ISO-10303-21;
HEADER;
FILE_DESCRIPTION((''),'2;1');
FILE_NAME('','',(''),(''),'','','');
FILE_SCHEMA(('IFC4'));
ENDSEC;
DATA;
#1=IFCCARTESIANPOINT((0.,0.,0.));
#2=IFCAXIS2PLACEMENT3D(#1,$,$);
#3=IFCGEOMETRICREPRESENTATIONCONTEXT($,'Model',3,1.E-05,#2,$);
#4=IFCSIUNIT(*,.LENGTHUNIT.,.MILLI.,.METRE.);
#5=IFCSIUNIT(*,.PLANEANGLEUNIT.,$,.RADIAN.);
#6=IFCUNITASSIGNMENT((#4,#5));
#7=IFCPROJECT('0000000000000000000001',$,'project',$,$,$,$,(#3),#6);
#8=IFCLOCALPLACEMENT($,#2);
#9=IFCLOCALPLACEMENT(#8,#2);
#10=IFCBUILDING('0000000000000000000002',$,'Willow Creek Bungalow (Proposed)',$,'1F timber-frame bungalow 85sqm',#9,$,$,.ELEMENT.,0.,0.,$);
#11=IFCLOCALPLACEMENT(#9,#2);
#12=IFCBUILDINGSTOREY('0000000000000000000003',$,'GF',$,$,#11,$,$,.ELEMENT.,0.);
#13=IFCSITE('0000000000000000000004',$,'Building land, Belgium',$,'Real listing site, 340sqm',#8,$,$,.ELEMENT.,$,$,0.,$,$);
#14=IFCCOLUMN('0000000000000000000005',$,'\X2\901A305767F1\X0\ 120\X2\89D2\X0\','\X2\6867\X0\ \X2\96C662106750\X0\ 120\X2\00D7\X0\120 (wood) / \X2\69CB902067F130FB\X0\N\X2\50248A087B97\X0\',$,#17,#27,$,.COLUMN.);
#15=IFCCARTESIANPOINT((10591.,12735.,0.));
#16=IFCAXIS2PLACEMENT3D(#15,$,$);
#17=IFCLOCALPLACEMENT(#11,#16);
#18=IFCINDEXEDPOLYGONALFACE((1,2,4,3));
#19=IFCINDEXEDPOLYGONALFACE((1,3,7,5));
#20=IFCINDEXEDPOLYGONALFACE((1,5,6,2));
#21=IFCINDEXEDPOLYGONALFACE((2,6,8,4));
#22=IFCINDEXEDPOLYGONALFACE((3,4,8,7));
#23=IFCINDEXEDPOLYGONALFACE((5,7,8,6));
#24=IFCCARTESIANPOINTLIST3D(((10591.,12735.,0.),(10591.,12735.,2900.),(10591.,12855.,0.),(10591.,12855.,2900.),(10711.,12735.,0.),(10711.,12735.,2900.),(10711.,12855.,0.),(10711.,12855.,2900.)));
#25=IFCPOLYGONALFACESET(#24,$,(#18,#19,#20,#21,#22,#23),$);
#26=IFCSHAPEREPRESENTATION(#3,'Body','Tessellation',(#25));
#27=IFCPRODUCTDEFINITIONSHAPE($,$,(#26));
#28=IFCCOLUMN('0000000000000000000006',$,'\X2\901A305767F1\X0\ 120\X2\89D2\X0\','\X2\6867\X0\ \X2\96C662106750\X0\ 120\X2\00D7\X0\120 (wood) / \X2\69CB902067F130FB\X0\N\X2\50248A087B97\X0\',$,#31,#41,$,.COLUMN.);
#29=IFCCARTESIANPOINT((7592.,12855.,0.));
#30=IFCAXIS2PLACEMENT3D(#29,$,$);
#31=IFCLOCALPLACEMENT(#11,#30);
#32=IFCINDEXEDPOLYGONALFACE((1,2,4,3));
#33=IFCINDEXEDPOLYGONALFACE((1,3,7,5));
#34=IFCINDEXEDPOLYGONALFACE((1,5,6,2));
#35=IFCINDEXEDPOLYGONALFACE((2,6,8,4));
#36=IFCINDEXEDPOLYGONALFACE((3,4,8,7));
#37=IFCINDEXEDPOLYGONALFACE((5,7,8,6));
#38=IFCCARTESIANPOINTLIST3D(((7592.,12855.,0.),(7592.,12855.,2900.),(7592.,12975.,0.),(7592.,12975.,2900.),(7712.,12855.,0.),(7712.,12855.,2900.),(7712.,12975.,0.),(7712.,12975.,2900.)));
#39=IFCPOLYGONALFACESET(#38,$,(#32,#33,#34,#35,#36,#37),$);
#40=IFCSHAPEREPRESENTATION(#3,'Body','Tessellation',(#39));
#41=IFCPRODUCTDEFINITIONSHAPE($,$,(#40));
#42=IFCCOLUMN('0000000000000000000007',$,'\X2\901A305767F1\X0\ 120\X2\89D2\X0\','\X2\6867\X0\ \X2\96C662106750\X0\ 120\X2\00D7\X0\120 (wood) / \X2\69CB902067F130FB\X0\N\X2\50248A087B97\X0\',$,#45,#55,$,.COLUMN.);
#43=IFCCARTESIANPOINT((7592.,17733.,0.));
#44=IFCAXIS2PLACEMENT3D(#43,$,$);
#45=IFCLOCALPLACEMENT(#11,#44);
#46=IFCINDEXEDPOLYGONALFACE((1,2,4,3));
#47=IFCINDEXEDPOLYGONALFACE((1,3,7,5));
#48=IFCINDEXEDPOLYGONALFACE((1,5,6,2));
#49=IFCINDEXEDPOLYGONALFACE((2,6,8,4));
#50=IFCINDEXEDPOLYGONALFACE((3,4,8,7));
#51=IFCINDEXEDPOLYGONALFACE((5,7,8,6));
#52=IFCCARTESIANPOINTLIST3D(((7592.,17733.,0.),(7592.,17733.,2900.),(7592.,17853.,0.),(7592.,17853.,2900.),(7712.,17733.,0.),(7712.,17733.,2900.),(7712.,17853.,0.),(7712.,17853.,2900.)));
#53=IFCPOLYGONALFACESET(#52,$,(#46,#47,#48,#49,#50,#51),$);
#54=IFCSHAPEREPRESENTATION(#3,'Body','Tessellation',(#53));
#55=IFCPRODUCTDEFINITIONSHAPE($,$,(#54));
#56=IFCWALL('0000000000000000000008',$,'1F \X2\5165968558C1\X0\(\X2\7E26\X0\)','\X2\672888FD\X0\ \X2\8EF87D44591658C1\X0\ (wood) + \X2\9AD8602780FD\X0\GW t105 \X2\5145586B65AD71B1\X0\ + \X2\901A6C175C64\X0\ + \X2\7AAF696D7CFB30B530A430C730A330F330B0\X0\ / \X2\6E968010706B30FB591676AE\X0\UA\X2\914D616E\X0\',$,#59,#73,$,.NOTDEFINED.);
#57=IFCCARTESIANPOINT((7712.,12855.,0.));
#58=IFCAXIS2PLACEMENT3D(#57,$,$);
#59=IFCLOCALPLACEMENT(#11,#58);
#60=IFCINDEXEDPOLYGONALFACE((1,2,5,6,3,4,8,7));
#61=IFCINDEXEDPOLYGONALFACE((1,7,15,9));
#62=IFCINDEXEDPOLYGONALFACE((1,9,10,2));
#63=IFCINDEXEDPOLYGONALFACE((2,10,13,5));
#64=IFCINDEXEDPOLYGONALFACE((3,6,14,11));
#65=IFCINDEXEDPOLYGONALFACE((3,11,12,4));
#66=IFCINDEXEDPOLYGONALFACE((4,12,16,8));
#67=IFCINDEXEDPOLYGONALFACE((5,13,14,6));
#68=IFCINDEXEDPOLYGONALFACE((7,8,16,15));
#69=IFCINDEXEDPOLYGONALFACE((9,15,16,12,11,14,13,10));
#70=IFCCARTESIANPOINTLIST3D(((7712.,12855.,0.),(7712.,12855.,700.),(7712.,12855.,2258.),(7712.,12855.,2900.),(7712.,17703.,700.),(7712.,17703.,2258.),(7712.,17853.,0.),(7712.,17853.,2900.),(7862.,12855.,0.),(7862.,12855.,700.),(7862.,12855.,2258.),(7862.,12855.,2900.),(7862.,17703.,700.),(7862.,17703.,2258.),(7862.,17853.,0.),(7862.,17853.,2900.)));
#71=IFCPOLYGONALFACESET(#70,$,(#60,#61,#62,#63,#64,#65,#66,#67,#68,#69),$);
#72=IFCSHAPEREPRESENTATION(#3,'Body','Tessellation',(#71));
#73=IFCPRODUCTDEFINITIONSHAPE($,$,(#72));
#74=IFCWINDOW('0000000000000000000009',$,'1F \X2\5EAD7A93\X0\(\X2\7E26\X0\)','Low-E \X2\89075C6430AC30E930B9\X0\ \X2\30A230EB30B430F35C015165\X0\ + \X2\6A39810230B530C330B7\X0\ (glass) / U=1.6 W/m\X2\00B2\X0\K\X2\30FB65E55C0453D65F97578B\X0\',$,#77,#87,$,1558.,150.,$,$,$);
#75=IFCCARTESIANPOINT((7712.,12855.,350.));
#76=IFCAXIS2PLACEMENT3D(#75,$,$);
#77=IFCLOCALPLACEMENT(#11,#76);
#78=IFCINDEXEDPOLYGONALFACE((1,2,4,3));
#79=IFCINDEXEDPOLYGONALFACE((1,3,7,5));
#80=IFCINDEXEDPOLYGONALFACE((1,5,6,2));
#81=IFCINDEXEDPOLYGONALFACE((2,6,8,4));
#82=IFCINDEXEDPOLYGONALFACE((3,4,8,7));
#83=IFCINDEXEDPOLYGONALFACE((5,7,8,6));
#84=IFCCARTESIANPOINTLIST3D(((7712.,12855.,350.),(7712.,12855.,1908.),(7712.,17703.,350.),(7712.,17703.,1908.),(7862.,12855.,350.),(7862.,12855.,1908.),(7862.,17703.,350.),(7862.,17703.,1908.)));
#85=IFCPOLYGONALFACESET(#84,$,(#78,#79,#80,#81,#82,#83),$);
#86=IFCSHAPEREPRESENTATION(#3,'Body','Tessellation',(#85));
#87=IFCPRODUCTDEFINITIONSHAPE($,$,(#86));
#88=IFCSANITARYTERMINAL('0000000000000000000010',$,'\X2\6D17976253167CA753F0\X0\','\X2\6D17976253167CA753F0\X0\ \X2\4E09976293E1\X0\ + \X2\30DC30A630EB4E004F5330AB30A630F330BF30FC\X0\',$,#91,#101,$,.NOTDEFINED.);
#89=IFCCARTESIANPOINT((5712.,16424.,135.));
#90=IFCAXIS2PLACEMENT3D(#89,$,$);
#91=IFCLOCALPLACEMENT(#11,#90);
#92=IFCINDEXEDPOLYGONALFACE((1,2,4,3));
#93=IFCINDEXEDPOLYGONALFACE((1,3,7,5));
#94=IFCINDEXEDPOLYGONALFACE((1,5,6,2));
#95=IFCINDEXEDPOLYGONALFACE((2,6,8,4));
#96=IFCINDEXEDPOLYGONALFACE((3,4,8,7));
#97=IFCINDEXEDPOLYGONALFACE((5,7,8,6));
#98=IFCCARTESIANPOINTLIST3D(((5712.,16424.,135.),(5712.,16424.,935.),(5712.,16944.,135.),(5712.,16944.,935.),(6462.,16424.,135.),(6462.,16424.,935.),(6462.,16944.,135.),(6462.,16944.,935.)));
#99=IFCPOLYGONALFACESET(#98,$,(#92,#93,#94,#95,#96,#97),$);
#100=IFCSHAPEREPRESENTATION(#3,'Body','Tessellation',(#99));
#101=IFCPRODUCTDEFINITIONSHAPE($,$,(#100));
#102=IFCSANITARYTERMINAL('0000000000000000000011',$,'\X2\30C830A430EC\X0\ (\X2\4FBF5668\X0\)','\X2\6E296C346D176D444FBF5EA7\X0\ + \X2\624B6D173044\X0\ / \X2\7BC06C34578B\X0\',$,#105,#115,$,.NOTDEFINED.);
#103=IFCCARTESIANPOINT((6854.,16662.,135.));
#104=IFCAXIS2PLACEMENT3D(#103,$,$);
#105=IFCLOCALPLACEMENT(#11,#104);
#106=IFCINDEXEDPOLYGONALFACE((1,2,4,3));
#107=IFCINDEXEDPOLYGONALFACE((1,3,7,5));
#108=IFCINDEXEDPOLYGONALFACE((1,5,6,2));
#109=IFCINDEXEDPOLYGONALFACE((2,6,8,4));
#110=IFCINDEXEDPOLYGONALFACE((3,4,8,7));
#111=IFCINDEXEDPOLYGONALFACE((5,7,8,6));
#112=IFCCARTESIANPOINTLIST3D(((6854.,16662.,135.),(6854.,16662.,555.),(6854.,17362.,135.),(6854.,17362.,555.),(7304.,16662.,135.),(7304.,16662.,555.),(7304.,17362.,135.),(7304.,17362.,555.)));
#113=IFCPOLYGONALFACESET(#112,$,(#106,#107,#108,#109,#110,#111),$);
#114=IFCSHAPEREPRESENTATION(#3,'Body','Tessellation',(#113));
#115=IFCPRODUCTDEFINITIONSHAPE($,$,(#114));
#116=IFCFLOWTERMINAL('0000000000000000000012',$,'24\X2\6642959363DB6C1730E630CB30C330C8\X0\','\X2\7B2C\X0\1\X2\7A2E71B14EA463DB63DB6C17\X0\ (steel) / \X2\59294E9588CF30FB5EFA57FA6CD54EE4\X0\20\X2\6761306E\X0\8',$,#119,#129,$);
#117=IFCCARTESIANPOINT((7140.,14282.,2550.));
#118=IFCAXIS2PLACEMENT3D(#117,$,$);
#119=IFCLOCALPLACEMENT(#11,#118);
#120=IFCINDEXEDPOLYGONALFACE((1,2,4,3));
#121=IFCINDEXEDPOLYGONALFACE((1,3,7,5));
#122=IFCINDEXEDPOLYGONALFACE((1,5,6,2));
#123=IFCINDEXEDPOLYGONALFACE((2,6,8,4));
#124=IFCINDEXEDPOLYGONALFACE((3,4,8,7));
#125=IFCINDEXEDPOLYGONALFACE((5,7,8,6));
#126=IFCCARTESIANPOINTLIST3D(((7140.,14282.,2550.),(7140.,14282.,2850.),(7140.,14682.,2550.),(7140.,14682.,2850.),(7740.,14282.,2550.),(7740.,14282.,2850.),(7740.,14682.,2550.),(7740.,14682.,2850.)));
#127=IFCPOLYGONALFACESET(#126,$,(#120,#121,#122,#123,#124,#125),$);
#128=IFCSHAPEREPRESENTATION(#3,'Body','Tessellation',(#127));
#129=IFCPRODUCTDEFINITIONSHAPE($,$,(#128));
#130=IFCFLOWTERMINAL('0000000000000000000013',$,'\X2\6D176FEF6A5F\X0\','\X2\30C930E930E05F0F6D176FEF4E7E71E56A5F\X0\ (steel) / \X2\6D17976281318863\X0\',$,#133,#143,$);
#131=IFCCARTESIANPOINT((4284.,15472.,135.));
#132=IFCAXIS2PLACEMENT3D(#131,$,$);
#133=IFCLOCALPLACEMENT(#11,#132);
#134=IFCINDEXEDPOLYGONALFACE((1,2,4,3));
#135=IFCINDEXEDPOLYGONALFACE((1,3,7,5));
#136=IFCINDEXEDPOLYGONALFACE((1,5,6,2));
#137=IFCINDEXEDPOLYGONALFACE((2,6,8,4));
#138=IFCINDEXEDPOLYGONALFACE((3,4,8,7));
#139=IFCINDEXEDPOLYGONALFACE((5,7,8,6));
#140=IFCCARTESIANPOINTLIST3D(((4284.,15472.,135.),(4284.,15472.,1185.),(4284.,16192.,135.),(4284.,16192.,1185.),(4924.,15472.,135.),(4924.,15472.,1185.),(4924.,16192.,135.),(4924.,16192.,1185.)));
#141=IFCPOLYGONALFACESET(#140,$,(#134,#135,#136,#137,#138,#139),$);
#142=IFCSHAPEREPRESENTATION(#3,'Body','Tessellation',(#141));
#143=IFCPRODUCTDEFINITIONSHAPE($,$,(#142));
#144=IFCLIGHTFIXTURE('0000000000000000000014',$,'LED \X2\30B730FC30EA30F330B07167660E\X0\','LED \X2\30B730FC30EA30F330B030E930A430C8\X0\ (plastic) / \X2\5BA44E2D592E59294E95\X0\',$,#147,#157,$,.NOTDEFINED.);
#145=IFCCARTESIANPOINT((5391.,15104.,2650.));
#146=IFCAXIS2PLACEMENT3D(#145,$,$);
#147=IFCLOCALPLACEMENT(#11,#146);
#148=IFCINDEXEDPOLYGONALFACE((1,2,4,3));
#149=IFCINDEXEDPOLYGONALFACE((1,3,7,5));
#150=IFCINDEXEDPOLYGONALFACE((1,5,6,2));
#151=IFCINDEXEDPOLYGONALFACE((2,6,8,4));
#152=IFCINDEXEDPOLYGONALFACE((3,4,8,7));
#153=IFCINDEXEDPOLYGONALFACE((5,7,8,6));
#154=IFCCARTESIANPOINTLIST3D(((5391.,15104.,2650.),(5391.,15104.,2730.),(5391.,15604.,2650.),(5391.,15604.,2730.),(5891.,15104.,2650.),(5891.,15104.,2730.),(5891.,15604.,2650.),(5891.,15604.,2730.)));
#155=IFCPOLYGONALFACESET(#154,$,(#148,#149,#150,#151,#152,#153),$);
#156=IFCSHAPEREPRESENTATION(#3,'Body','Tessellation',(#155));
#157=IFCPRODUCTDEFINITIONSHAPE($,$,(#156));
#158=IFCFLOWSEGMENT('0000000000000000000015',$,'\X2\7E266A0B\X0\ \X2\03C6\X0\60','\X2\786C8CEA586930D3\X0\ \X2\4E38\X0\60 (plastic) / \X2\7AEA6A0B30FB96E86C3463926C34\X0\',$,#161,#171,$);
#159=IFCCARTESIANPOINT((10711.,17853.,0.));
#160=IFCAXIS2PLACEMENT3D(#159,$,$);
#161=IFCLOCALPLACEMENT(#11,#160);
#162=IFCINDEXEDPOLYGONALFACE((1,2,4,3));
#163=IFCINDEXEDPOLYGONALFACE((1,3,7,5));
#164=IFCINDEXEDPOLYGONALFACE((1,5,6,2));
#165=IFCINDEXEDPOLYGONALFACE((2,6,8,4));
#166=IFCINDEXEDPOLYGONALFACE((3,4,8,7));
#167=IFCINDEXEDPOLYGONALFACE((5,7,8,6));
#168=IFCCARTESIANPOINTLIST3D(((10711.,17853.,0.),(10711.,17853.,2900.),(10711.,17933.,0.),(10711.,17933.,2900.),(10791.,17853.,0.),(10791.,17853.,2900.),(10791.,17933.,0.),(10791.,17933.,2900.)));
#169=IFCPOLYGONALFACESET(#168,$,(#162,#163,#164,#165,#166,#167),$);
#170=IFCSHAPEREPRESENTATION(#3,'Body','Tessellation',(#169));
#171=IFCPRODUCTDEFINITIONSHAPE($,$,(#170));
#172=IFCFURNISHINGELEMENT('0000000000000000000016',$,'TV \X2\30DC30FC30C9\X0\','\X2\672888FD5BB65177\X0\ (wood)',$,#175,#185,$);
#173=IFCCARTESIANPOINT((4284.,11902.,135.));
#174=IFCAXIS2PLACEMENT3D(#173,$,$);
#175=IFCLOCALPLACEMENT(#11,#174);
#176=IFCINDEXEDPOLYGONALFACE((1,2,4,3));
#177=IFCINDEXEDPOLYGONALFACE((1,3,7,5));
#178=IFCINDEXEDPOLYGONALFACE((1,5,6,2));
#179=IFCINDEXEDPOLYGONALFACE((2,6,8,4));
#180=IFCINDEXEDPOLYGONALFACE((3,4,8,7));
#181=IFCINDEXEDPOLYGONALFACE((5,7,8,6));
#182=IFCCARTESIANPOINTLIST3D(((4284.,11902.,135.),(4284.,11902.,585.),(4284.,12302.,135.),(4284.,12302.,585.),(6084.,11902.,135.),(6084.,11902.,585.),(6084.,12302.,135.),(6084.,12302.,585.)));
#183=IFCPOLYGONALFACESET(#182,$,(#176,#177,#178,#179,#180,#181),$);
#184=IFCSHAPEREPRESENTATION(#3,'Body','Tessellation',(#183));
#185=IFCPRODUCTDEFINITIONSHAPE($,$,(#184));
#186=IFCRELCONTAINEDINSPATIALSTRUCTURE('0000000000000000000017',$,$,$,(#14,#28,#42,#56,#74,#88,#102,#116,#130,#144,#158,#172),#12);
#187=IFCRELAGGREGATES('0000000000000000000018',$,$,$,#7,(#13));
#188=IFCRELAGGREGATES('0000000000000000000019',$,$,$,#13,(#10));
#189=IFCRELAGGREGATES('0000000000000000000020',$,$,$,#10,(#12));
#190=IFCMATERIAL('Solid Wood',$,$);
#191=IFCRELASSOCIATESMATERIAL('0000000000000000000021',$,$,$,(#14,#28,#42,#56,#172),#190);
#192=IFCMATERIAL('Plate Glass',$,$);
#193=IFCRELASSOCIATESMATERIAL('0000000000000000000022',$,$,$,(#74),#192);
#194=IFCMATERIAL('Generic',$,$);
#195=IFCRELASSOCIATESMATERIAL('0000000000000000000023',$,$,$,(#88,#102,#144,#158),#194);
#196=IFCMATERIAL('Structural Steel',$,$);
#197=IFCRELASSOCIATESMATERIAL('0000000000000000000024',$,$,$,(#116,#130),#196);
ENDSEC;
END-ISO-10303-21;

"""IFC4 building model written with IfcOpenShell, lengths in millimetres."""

from ifc_helpers import new_model, si_unit, frame, frame_2d, origin, place, context, project, spatial, rectangle, extrude, material, element, fill, save


model = new_model("IFC4")

# Units and contexts
model_context = context("Model", 3, precision=1e-05, world=origin())
ifc_project = project(units=[si_unit("LENGTHUNIT", "METRE", prefix="MILLI"), si_unit("PLANEANGLEUNIT", "RADIAN")], contexts=[model_context])

# Site, building, storey
site_placement = place(None, origin())
site = spatial("IfcSite", under=ifc_project, at=site_placement, Name="Building land, Belgium", ObjectType="Real listing site, 340sqm", CompositionType="ELEMENT", RefElevation=0.0)
building_placement = place(site_placement, origin())
building = spatial("IfcBuilding", under=site, at=building_placement, Name="Willow Creek Bungalow (Proposed)", ObjectType="1F timber-frame bungalow 85sqm", CompositionType="ELEMENT", ElevationOfRefHeight=0.0, ElevationOfTerrain=0.0)
storey_placement = place(building_placement, origin())
storey = spatial("IfcBuildingStorey", under=building, at=storey_placement, Name="GF", CompositionType="ELEMENT", Elevation=0.0)

# Columns
ifc_material_1 = material(Name="Solid Wood")
column_1_placement = place(storey_placement, frame((10591.0, 12735.0, 0.0)))
element("IfcColumn", 1, at=column_1_placement, inside=storey, material=ifc_material_1, Name="通し柱 120角", Description="桧 集成材 120×120 (wood) / 構造柱・N値計算", PredefinedType="COLUMN", context=model_context, shape_type="SweptSolid", body=[
    extrude(rectangle(XDim=120.0, YDim=120.0, at=frame_2d((60.0, 60.0))), frame((10591.0, 12735.0, 0.0)), (0.0, 0.0, 1.0), 2900.0),
])
column_2_placement = place(storey_placement, frame((7592.0, 12855.0, 0.0)))
element("IfcColumn", 2, at=column_2_placement, inside=storey, material=ifc_material_1, Name="通し柱 120角", Description="桧 集成材 120×120 (wood) / 構造柱・N値計算", PredefinedType="COLUMN", context=model_context, shape_type="SweptSolid", body=[
    extrude(rectangle(XDim=120.0, YDim=120.0, at=frame_2d((60.0, 60.0))), frame((7592.0, 12855.0, 0.0)), (0.0, 0.0, 1.0), 2900.0),
])
column_3_placement = place(storey_placement, frame((7592.0, 17733.0, 0.0)))
element("IfcColumn", 3, at=column_3_placement, inside=storey, material=ifc_material_1, Name="通し柱 120角", Description="桧 集成材 120×120 (wood) / 構造柱・N値計算", PredefinedType="COLUMN", context=model_context, shape_type="SweptSolid", body=[
    extrude(rectangle(XDim=120.0, YDim=120.0, at=frame_2d((60.0, 60.0))), frame((7592.0, 17733.0, 0.0)), (0.0, 0.0, 1.0), 2900.0),
])

# Wall, opening, window
wall_1_placement = place(storey_placement, frame((7712.0, 12855.0, 0.0)))
wall_1 = element("IfcWall", 4, at=wall_1_placement, inside=storey, material=ifc_material_1, Name="1F 入隅壁(縦)", Description="木製 軸組外壁 (wood) + 高性能GW t105 充填断熱 + 通気層 + 窯業系サイディング / 準耐火・外皮UA配慮", PredefinedType="NOTDEFINED", context=model_context, shape_type="SweptSolid", body=[
    extrude(rectangle(XDim=150.0, YDim=4998.0, at=frame_2d((75.0, 2499.0))), frame((7712.0, 12855.0, 0.0)), (0.0, 0.0, 1.0), 2900.0),
])
opening_placement = place(storey_placement, frame((7712.0, 12855.0, 350.0)))
opening = element("IfcOpeningElement", 5, at=opening_placement, cuts=wall_1, PredefinedType="NOTDEFINED", context=model_context, shape_type="SweptSolid", body=[
    extrude(rectangle(XDim=150.0, YDim=4848.0, at=frame_2d((75.0, 2424.0))), frame((7712.0, 12855.0, 350.0)), (0.0, 0.0, 1.0), 1558.0),
])
ifc_material_2 = material(Name="Plate Glass")
window_placement = place(storey_placement, frame((7712.0, 12855.0, 350.0)))
window = element("IfcWindow", 6, at=window_placement, inside=storey, material=ifc_material_2, Name="1F 庭窓(縦)", Description="Low-E 複層ガラス アルゴン封入 + 樹脂サッシ (glass) / U=1.6 W/m²K・日射取得型", OverallHeight=1558.0, OverallWidth=150.0, context=model_context, shape_type="SweptSolid", body=[
    extrude(rectangle(XDim=150.0, YDim=4848.0, at=frame_2d((75.0, 2424.0))), frame((7712.0, 12855.0, 350.0)), (0.0, 0.0, 1.0), 1558.0),
])
fill(opening, window)

# Sanitary terminals
ifc_material_3 = material(Name="Generic")
sanitary_terminal_1_placement = place(storey_placement, frame((5712.0, 16424.0, 135.0)))
element("IfcSanitaryTerminal", 7, at=sanitary_terminal_1_placement, inside=storey, material=ifc_material_3, Name="洗面化粧台", Description="洗面化粧台 三面鏡 + ボウル一体カウンター", PredefinedType="NOTDEFINED", context=model_context, shape_type="SweptSolid", body=[
    extrude(rectangle(XDim=750.0, YDim=520.0, at=frame_2d((375.0, 260.0))), frame((5712.0, 16424.0, 135.0)), (0.0, 0.0, 1.0), 800.0),
])
sanitary_terminal_2_placement = place(storey_placement, frame((6854.0, 16662.0, 135.0)))
element("IfcSanitaryTerminal", 8, at=sanitary_terminal_2_placement, inside=storey, material=ifc_material_3, Name="トイレ (便器)", Description="温水洗浄便座 + 手洗い / 節水型", PredefinedType="NOTDEFINED", context=model_context, shape_type="SweptSolid", body=[
    extrude(rectangle(XDim=450.0, YDim=700.0, at=frame_2d((225.0, 350.0))), frame((6854.0, 16662.0, 135.0)), (0.0, 0.0, 1.0), 420.0),
])

# Flow terminals
ifc_material_4 = material(Name="Structural Steel")
flow_terminal_1_placement = place(storey_placement, frame((7140.0, 14282.0, 2550.0)))
element("IfcFlowTerminal", 9, at=flow_terminal_1_placement, inside=storey, material=ifc_material_4, Name="24時間換気ユニット", Description="第1種熱交換換気 (steel) / 天井裏・建基法令20条の8", context=model_context, shape_type="SweptSolid", body=[
    extrude(rectangle(XDim=600.0, YDim=400.0, at=frame_2d((300.0, 200.0))), frame((7140.0, 14282.0, 2550.0)), (0.0, 0.0, 1.0), 300.0),
])
flow_terminal_2_placement = place(storey_placement, frame((4284.0, 15472.0, 135.0)))
element("IfcFlowTerminal", 10, at=flow_terminal_2_placement, inside=storey, material=ifc_material_4, Name="洗濯機", Description="ドラム式洗濯乾燥機 (steel) / 洗面脱衣", context=model_context, shape_type="SweptSolid", body=[
    extrude(rectangle(XDim=640.0, YDim=720.0, at=frame_2d((320.0, 360.0))), frame((4284.0, 15472.0, 135.0)), (0.0, 0.0, 1.0), 1050.0),
])

# Light fixture
light_fixture_placement = place(storey_placement, frame((5391.0, 15104.0, 2650.0)))
element("IfcLightFixture", 11, at=light_fixture_placement, inside=storey, material=ifc_material_3, Name="LED シーリング照明", Description="LED シーリングライト (plastic) / 室中央天井", PredefinedType="NOTDEFINED", context=model_context, shape_type="SweptSolid", body=[
    extrude(rectangle(XDim=500.0, YDim=500.0, at=frame_2d((250.0, 250.0))), frame((5391.0, 15104.0, 2650.0)), (0.0, 0.0, 1.0), 80.0),
])

# Flow segment
flow_segment_placement = place(storey_placement, frame((10711.0, 17853.0, 0.0)))
element("IfcFlowSegment", 12, at=flow_segment_placement, inside=storey, material=ifc_material_3, Name="縦樋 φ60", Description="硬質塩ビ 丸60 (plastic) / 竪樋・雨水排水", context=model_context, shape_type="SweptSolid", body=[
    extrude(rectangle(XDim=80.0, YDim=80.0, at=frame_2d((40.0, 40.0))), frame((10711.0, 17853.0, 0.0)), (0.0, 0.0, 1.0), 2900.0),
])

# Furnishing element
furnishing_placement = place(storey_placement, frame((4284.0, 11902.0, 135.0)))
element("IfcFurnishingElement", 13, at=furnishing_placement, inside=storey, material=ifc_material_1, Name="TV ボード", Description="木製家具 (wood)", context=model_context, shape_type="SweptSolid", body=[
    extrude(rectangle(XDim=1800.0, YDim=400.0, at=frame_2d((900.0, 200.0))), frame((4284.0, 11902.0, 135.0)), (0.0, 0.0, 1.0), 450.0),
])

save(model, "model.ifc")
